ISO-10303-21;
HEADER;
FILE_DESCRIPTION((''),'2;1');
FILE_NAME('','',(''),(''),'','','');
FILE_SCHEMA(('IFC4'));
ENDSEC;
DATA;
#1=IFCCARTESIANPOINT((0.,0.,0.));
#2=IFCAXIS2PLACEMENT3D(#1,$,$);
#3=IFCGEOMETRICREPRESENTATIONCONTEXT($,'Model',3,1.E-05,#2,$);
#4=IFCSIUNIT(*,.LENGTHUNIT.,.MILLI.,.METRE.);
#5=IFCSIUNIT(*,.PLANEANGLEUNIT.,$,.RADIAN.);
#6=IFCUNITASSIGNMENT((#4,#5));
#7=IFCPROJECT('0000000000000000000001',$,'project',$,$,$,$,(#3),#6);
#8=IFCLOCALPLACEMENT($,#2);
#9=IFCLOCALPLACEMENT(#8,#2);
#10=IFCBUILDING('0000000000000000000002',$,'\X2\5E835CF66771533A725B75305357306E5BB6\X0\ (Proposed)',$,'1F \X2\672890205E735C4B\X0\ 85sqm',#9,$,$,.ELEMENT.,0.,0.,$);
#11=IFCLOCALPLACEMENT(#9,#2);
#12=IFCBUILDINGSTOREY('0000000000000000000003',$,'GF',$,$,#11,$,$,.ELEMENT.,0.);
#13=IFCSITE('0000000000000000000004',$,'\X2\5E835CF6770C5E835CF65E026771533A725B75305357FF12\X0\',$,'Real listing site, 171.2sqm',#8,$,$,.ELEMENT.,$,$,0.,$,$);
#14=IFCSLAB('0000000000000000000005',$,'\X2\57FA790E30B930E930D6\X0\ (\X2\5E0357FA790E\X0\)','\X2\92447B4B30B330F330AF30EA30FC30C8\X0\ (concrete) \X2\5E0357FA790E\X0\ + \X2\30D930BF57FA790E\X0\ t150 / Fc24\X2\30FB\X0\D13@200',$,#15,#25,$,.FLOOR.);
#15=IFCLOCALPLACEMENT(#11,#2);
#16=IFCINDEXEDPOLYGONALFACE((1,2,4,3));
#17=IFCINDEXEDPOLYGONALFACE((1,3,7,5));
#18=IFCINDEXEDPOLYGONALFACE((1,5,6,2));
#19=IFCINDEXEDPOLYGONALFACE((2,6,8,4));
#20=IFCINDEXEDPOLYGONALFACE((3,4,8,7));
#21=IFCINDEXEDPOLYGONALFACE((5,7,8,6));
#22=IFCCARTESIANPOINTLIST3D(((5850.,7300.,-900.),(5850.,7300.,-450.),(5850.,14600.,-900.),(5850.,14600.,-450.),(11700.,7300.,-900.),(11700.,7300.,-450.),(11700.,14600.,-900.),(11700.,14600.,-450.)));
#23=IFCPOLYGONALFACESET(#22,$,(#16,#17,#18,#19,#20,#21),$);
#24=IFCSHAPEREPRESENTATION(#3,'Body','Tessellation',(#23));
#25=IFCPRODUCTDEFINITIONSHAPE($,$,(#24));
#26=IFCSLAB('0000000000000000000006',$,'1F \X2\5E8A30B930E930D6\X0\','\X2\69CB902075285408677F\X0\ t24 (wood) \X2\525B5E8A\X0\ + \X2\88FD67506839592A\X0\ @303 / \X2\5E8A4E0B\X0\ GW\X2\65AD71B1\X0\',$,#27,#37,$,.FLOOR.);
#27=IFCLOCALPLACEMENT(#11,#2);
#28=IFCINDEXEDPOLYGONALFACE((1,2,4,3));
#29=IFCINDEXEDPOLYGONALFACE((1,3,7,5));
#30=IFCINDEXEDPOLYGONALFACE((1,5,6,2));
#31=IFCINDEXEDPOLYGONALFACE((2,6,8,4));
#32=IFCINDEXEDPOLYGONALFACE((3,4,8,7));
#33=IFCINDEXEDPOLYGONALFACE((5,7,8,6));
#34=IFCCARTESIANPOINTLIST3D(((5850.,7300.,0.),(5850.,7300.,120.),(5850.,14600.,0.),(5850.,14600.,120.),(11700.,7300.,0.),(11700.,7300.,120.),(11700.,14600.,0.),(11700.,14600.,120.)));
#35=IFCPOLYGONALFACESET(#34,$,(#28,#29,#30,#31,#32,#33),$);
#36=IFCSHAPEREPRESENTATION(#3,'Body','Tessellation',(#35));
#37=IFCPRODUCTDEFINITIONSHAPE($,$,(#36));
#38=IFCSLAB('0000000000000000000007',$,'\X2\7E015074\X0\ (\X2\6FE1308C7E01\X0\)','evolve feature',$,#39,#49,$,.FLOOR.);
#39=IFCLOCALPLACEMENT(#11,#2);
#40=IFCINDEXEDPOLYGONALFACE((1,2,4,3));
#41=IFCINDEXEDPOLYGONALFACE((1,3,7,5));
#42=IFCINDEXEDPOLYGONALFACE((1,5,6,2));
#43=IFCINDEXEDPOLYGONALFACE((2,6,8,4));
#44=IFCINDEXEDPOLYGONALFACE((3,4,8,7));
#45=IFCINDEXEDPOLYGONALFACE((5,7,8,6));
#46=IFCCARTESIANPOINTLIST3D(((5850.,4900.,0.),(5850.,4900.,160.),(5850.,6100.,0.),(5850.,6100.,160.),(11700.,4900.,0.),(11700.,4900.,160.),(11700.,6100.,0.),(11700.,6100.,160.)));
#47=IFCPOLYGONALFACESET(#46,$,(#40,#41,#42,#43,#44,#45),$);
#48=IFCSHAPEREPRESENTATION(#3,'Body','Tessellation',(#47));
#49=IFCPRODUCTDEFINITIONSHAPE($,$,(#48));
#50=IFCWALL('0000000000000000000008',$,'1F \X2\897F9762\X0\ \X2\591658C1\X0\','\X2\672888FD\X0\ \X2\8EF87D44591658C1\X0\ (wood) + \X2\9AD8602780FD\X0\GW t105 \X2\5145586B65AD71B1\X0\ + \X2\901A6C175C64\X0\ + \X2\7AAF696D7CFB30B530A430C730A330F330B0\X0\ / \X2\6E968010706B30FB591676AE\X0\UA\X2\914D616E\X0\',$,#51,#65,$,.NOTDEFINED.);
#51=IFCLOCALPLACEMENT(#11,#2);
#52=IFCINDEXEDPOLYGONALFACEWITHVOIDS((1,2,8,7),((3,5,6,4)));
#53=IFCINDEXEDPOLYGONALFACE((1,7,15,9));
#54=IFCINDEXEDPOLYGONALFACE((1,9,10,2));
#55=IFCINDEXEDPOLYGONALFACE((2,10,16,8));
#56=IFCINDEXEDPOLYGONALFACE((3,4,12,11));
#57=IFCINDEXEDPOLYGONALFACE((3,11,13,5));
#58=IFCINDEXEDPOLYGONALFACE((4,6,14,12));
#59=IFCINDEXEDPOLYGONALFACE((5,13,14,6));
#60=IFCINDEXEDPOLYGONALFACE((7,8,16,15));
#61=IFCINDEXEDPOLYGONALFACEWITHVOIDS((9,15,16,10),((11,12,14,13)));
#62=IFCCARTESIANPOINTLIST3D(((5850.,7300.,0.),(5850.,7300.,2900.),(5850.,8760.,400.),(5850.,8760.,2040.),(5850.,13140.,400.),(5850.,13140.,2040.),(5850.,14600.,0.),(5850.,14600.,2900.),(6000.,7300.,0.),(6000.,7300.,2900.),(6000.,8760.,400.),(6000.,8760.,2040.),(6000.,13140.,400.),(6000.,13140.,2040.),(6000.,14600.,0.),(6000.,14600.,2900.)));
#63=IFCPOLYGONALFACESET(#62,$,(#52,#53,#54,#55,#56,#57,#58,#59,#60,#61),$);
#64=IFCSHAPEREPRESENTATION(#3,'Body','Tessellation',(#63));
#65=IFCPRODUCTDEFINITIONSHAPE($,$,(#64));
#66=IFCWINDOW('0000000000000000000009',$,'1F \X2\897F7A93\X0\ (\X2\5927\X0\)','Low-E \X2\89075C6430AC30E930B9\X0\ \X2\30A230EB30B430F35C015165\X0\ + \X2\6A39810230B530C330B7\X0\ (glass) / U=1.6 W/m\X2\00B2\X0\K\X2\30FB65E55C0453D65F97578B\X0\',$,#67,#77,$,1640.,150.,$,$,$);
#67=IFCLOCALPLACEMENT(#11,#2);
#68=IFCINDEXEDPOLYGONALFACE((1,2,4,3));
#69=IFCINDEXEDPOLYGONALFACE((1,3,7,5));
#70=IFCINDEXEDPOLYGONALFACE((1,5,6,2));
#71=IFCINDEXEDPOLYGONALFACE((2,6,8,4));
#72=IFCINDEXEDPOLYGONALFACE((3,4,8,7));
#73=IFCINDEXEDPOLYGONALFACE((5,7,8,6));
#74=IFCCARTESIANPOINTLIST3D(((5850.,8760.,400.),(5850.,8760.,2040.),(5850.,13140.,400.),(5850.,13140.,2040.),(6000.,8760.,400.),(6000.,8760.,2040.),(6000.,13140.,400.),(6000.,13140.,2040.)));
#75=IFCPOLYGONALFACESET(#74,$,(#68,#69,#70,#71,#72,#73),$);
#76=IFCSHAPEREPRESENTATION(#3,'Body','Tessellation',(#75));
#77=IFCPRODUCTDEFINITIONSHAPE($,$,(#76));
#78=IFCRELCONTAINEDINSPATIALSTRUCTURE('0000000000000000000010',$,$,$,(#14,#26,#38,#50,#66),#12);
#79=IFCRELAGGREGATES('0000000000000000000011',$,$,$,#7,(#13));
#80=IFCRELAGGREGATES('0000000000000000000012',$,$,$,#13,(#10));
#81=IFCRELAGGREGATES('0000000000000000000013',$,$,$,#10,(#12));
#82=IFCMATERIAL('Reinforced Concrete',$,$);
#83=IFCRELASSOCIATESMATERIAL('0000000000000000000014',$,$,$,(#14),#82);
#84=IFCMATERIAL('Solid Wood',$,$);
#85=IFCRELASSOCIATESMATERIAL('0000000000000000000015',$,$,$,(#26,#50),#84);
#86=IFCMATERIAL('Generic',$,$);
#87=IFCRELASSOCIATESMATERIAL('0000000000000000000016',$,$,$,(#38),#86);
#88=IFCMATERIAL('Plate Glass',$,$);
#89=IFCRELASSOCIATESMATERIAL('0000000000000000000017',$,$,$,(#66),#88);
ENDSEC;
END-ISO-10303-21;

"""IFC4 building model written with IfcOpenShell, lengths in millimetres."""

from ifc_helpers import new_model, si_unit, frame, frame_2d, origin, place, context, project, spatial, rectangle, extrude, material, element, fill, save


model = new_model("IFC4")

# Units and contexts
model_context = context("Model", 3, precision=1e-05, world=origin())
ifc_project = project(units=[si_unit("LENGTHUNIT", "METRE", prefix="MILLI"), si_unit("PLANEANGLEUNIT", "RADIAN")], contexts=[model_context])

# Site, building, storey
site_placement = place(None, origin())
site = spatial("IfcSite", under=ifc_project, at=site_placement, Name="広島県広島市東区牛田南２", ObjectType="Real listing site, 171.2sqm", CompositionType="ELEMENT", RefElevation=0.0)
building_placement = place(site_placement, origin())
building = spatial("IfcBuilding", under=site, at=building_placement, Name="広島東区牛田南の家 (Proposed)", ObjectType="1F 木造平屋 85sqm", CompositionType="ELEMENT", ElevationOfRefHeight=0.0, ElevationOfTerrain=0.0)
storey_placement = place(building_placement, origin())
storey = spatial("IfcBuildingStorey", under=building, at=storey_placement, Name="GF", CompositionType="ELEMENT", Elevation=0.0)

# Slabs
ifc_material_1 = material(Name="Reinforced Concrete")
slab_1_placement = place(storey_placement, frame((2925.0, 3650.0, -450.0)))
element("IfcSlab", 1, at=slab_1_placement, inside=storey, material=ifc_material_1, Name="基礎スラブ (布基礎)", Description="鉄筋コンクリート (concrete) 布基礎 + ベタ基礎 t150 / Fc24・D13@200", PredefinedType="FLOOR", context=model_context, shape_type="SweptSolid", body=[
    extrude(rectangle(XDim=5850.0, YDim=7300.0, at=frame_2d((2925.0, 3650.0))), frame((2925.0, 3650.0, -450.0)), (0.0, 0.0, 1.0), 450.0),
])
ifc_material_2 = material(Name="Solid Wood")
slab_2_placement = place(storey_placement, frame((2925.0, 3650.0, 0.0)))
element("IfcSlab", 2, at=slab_2_placement, inside=storey, material=ifc_material_2, Name="1F 床スラブ", Description="構造用合板 t24 (wood) 剛床 + 製材根太 @303 / 床下 GW断熱", PredefinedType="FLOOR", context=model_context, shape_type="SweptSolid", body=[
    extrude(rectangle(XDim=5850.0, YDim=7300.0, at=frame_2d((2925.0, 3650.0))), frame((2925.0, 3650.0, 0.0)), (0.0, 0.0, 1.0), 120.0),
])
ifc_material_3 = material(Name="Generic")
slab_3_placement = place(storey_placement, frame((2925.0, 2450.0, 0.0)))
element("IfcSlab", 3, at=slab_3_placement, inside=storey, material=ifc_material_3, Name="縁側 (濡れ縁)", Description="evolve feature", PredefinedType="FLOOR", context=model_context, shape_type="SweptSolid", body=[
    extrude(rectangle(XDim=5850.0, YDim=1200.0, at=frame_2d((2925.0, 600.0))), frame((2925.0, 2450.0, 0.0)), (0.0, 0.0, 1.0), 160.0),
])

# Shared definitions
ifc_material_4 = material(Name="Plate Glass")

# Wall, opening, window
wall_1_placement = place(storey_placement, frame((2925.0, 3650.0, 0.0)))
wall_1 = element("IfcWall", 4, at=wall_1_placement, inside=storey, material=ifc_material_2, Name="1F 西面 外壁", Description="木製 軸組外壁 (wood) + 高性能GW t105 充填断熱 + 通気層 + 窯業系サイディング / 準耐火・外皮UA配慮", PredefinedType="NOTDEFINED", context=model_context, shape_type="SweptSolid", body=[
    extrude(rectangle(XDim=150.0, YDim=7300.0, at=frame_2d((75.0, 3650.0))), frame((2925.0, 3650.0, 0.0)), (0.0, 0.0, 1.0), 2900.0),
])
opening_1_placement = place(storey_placement, frame((2925.0, 4380.0, 200.0)))
opening_1 = element("IfcOpeningElement", 5, at=opening_1_placement, cuts=wall_1, PredefinedType="NOTDEFINED", context=model_context, shape_type="SweptSolid", body=[
    extrude(rectangle(XDim=150.0, YDim=4380.0, at=frame_2d((75.0, 2190.0))), frame((2925.0, 4380.0, 200.0)), (0.0, 0.0, 1.0), 1640.0),
])
window_1_placement = place(storey_placement, frame((2925.0, 4380.0, 200.0)))
window_1 = element("IfcWindow", 6, at=window_1_placement, inside=storey, material=ifc_material_4, Name="1F 西窓 (大)", Description="Low-E 複層ガラス アルゴン封入 + 樹脂サッシ (glass) / U=1.6 W/m²K・日射取得型", OverallHeight=1640.0, OverallWidth=150.0, context=model_context, shape_type="SweptSolid", body=[
    extrude(rectangle(XDim=150.0, YDim=4380.0, at=frame_2d((75.0, 2190.0))), frame((2925.0, 4380.0, 200.0)), (0.0, 0.0, 1.0), 1640.0),
])
fill(opening_1, window_1)

save(model, "model.ifc")
